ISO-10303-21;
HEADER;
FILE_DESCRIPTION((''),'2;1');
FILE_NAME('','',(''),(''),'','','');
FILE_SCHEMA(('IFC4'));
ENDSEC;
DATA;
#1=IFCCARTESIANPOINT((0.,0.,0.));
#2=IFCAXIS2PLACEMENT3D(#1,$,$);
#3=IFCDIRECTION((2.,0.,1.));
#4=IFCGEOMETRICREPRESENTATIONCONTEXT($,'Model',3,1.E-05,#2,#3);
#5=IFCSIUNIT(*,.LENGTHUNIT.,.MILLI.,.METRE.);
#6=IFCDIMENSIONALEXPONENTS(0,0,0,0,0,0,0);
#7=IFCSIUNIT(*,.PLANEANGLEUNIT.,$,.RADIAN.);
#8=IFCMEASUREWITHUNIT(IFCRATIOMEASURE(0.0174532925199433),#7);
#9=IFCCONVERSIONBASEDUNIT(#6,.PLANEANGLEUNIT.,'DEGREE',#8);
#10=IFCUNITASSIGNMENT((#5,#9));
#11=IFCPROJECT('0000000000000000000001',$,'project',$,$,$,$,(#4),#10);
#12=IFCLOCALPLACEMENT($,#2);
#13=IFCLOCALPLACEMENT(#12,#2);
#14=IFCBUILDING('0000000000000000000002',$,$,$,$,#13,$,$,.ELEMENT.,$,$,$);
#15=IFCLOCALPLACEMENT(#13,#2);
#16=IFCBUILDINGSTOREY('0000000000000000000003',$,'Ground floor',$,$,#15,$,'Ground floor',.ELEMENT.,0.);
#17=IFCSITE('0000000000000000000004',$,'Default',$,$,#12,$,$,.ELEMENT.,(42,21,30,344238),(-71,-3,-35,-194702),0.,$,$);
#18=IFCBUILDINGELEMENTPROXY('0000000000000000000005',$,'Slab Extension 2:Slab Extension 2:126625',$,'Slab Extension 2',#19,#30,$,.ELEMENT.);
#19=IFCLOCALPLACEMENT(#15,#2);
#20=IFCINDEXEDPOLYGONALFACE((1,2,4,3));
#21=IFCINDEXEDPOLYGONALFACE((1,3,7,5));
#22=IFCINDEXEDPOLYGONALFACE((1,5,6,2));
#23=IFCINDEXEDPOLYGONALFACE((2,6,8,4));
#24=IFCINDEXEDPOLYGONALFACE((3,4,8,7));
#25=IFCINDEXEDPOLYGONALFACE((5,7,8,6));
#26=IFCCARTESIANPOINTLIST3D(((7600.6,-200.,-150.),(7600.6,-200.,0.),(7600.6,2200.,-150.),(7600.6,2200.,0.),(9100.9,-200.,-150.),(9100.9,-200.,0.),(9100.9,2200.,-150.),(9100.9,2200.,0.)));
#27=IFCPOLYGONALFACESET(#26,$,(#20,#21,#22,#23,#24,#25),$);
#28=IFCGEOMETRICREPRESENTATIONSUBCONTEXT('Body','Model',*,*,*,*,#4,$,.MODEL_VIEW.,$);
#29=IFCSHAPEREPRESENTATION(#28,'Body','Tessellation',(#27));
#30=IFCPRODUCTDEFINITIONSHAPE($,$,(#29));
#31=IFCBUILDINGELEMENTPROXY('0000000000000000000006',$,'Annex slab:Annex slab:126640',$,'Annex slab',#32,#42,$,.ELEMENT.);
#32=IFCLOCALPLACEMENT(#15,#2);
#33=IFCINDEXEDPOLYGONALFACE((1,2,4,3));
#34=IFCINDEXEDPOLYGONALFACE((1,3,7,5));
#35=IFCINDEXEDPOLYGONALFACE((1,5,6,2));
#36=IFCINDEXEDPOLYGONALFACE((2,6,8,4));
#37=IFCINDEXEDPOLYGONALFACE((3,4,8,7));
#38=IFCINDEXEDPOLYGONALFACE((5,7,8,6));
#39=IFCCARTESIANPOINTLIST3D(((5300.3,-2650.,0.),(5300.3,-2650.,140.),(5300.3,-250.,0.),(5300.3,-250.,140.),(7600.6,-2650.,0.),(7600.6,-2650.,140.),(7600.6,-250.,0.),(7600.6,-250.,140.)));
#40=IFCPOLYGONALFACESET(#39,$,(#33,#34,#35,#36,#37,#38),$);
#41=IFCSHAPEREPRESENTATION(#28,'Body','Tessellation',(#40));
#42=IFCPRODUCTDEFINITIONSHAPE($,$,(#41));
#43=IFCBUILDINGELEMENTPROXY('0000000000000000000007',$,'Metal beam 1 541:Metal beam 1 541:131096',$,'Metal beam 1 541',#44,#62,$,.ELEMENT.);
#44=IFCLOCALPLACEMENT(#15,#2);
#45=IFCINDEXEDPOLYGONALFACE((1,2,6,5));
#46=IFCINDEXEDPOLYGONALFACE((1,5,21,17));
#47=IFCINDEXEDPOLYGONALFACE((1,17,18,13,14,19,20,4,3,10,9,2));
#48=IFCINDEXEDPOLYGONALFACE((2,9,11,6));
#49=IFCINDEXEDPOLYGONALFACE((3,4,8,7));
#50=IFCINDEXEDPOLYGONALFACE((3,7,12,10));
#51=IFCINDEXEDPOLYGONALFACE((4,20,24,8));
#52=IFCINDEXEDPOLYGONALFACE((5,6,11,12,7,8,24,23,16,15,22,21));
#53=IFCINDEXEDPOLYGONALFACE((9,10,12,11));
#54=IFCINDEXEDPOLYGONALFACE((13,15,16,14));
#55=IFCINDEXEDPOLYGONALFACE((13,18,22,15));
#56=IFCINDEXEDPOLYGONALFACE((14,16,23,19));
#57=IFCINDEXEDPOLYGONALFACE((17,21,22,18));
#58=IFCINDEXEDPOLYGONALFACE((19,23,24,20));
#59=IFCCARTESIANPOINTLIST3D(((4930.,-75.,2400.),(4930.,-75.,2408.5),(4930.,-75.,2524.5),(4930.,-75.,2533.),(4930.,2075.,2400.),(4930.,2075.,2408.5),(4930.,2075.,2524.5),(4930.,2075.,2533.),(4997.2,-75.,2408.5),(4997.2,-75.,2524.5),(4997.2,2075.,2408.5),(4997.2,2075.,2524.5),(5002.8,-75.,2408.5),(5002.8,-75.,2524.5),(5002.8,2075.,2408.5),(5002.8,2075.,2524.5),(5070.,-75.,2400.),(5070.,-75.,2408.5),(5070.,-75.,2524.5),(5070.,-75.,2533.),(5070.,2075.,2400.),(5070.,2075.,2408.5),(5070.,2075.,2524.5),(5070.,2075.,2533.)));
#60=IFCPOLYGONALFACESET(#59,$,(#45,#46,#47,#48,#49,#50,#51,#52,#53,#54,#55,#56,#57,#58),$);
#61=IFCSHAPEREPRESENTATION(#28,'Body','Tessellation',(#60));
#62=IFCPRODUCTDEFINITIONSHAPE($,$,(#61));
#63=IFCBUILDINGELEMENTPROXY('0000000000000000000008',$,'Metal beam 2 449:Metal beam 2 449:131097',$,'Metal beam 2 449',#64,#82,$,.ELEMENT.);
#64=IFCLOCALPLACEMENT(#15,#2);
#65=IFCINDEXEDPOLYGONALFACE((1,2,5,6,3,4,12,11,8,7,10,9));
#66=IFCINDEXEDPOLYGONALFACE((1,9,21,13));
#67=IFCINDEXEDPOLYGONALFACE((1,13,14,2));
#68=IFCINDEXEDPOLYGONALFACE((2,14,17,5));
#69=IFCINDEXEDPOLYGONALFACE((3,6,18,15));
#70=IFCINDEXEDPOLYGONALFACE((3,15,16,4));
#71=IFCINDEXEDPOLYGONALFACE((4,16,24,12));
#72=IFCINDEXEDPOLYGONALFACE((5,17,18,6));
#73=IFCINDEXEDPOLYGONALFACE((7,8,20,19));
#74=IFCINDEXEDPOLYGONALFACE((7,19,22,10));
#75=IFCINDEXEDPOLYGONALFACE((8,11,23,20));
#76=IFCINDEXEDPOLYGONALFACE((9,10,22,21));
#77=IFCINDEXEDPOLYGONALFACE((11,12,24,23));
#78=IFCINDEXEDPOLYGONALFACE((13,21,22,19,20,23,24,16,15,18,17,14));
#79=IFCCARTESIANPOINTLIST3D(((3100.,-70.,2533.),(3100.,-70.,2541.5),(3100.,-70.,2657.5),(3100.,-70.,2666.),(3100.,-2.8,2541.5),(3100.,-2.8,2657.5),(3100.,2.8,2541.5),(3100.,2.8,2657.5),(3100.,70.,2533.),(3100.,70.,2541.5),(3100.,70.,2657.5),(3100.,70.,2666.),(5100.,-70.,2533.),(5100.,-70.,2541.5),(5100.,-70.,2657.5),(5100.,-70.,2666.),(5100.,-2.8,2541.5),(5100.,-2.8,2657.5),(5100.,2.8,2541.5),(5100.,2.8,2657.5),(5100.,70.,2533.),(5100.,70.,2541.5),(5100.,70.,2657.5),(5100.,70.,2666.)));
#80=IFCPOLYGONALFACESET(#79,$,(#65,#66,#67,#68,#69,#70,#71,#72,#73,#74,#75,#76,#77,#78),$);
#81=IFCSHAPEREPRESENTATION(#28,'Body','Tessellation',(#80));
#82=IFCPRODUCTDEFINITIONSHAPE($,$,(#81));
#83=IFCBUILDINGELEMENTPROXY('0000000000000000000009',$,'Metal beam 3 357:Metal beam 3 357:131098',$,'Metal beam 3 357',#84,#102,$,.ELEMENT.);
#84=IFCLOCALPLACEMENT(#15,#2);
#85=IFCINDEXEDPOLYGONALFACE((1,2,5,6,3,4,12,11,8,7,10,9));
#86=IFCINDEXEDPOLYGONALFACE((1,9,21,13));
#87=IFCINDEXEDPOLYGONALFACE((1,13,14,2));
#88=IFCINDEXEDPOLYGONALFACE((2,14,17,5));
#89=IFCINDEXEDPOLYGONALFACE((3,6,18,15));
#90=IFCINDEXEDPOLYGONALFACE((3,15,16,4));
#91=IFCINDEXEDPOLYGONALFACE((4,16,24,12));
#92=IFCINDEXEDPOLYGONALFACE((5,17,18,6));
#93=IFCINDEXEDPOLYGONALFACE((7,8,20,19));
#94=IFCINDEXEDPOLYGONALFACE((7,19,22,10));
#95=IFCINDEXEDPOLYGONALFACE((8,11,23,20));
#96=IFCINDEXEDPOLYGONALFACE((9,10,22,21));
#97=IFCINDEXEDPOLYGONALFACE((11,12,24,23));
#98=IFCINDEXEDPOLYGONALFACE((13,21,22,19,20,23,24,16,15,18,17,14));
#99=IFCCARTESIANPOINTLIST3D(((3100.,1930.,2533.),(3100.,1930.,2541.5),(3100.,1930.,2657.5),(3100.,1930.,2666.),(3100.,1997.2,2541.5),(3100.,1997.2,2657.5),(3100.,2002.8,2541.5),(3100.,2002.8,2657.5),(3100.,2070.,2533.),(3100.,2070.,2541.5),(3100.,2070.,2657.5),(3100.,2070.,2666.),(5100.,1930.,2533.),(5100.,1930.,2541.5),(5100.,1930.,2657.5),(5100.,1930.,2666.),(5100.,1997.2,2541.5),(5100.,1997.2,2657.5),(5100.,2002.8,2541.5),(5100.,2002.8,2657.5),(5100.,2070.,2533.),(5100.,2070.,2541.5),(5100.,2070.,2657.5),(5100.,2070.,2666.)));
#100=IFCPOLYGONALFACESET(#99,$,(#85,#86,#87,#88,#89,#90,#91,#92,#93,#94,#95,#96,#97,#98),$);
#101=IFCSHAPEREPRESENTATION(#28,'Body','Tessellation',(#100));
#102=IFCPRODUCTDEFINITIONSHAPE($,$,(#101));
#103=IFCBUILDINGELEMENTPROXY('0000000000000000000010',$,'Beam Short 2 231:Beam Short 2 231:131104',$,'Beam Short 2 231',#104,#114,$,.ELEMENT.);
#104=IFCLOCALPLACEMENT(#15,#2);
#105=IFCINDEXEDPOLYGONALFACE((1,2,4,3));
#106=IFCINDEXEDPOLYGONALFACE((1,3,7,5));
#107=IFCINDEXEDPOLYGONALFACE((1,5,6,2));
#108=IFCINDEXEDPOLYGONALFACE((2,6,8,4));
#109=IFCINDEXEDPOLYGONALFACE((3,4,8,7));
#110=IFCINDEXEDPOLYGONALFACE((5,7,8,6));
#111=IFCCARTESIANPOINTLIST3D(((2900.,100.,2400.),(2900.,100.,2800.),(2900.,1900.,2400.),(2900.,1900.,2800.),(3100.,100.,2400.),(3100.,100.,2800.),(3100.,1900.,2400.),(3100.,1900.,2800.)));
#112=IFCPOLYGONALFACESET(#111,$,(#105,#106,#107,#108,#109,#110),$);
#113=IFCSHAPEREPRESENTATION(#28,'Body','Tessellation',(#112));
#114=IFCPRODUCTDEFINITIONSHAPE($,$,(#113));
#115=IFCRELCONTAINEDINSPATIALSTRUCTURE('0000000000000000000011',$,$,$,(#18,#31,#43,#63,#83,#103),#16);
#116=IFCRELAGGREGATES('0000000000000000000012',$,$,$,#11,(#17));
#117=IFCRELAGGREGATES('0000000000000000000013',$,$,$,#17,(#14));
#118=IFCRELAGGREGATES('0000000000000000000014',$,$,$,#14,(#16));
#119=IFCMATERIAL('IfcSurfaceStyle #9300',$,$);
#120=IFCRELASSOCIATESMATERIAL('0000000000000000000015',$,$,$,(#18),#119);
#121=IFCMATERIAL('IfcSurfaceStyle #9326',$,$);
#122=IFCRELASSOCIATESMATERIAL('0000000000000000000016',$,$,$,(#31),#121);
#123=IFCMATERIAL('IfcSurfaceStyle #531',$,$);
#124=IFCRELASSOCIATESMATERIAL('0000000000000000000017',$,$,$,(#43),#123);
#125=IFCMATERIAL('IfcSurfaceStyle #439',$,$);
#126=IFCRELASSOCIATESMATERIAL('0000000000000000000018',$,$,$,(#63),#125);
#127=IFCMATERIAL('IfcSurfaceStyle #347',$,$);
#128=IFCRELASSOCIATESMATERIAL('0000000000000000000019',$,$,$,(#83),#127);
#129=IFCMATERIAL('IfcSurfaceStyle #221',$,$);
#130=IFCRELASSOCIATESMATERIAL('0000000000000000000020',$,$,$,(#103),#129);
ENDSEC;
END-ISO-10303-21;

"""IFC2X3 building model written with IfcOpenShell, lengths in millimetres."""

from ifc_helpers import new_model, entity, si_unit, converted_unit, direction, frame, frame_2d, origin, origin_2d_with_axis, place, context, subcontext, project, spatial, rectangle, i_section, extrude, source, transform, mapped, material, element, save


model = new_model("IFC2X3")

# Units and contexts
model_context = context("Model", 3, precision=1e-05, world=origin(), true_north=direction((2.0, 0.0, 1.0)))
body_context = subcontext(model_context, "Body", "Model", "MODEL_VIEW")
ifc_project = project(units=[si_unit("LENGTHUNIT", "METRE", prefix="MILLI"), converted_unit("PLANEANGLEUNIT", "DEGREE", entity("IfcRatioMeasure", 0.0174532925199433), si_unit("PLANEANGLEUNIT", "RADIAN"), dimensions=[0, 0, 0, 0, 0, 0, 0])], contexts=[model_context])

# Site, building, storey
site_placement = place(None, origin())
site = spatial("IfcSite", under=ifc_project, at=site_placement, Name="Default", CompositionType="ELEMENT", RefLatitude=(42, 21, 30, 344238), RefLongitude=(-71, -3, -35, -194702), RefElevation=0.0)
building_placement = place(site_placement, origin())
building = spatial("IfcBuilding", under=site, at=building_placement, CompositionType="ELEMENT")
storey_placement = place(building_placement, origin())
storey = spatial("IfcBuildingStorey", under=building, at=storey_placement, Name="Ground floor", LongName="Ground floor", CompositionType="ELEMENT", Elevation=0.0)

# Building element proxies
ifc_material_1 = material(Name="IfcSurfaceStyle #9300")
shared_shape_1 = source(origin(), body_context, "Body", "SweptSolid", [
    extrude(rectangle(XDim=1500.3, YDim=2400.0, at=origin_2d_with_axis()), frame((750.1, 1200.0, 0.0)), (0.0, 0.0, 1.0), 150.0),
])
proxy_1_placement = place(building_placement, frame((7600.6, -200.0, -150.0)))
element("IfcBuildingElementProxy", 1, at=proxy_1_placement, inside=storey, material=ifc_material_1, Name="Slab Extension 2:Slab Extension 2:126625", ObjectType="Slab Extension 2", CompositionType="ELEMENT", context=body_context, shape_type="MappedRepresentation", body=[
    mapped(shared_shape_1, transform((0.0, 0.0, 0.0), scale=1.0)),
])
ifc_material_2 = material(Name="IfcSurfaceStyle #9326")
shared_shape_2 = source(origin(), body_context, "Body", "SweptSolid", [
    extrude(rectangle(XDim=2300.3, YDim=2400.0, at=frame_2d((0.0, 0.0), x_axis=(1.0, 0.0))), frame((1150.2, 1200.0, 0.0)), (0.0, 0.0, 1.0), 140.0),
])
proxy_2_placement = place(building_placement, frame((5300.3, -2650.0, 0.0)))
element("IfcBuildingElementProxy", 2, at=proxy_2_placement, inside=storey, material=ifc_material_2, Name="Annex slab:Annex slab:126640", ObjectType="Annex slab", CompositionType="ELEMENT", context=body_context, shape_type="MappedRepresentation", body=[
    mapped(shared_shape_2, transform((0.0, 0.0, 0.0), scale=1.0)),
])
ifc_material_3 = material(Name="IfcSurfaceStyle #531")
shared_shape_3 = source(origin(), body_context, "Body", "SweptSolid", [
    extrude(i_section(OverallWidth=140.0, OverallDepth=133.0, WebThickness=5.5, FlangeThickness=8.5, at=frame_2d((0.0, 0.0), x_axis=(1.0, 0.0))), frame((70.0, 0.0, 66.5), z_axis=(0.0, 1.0, 0.0), x_axis=(-1.0, 0.0, 0.0)), (0.0, 0.0, 1.0), 2150.0),
])
proxy_3_placement = place(building_placement, frame((4930.0, -75.0, 2400.0)))
element("IfcBuildingElementProxy", 3, at=proxy_3_placement, inside=storey, material=ifc_material_3, Name="Metal beam 1 541:Metal beam 1 541:131096", ObjectType="Metal beam 1 541", CompositionType="ELEMENT", context=body_context, shape_type="MappedRepresentation", body=[
    mapped(shared_shape_3, transform((0.0, 0.0, 0.0), scale=1.0)),
])
ifc_material_4 = material(Name="IfcSurfaceStyle #439")
shared_shape_4 = source(origin(), body_context, "Body", "SweptSolid", [
    extrude(i_section(OverallWidth=140.0, OverallDepth=133.0, WebThickness=5.5, FlangeThickness=8.5, at=frame_2d((0.0, 0.0), x_axis=(1.0, 0.0))), frame((0.0, 70.0, 66.5), z_axis=(1.0, 0.0, 0.0), x_axis=(0.0, 1.0, 0.0)), (0.0, 0.0, 1.0), 2000.0),
])
proxy_4_placement = place(building_placement, frame((3100.0, -70.0, 2533.0)))
element("IfcBuildingElementProxy", 4, at=proxy_4_placement, inside=storey, material=ifc_material_4, Name="Metal beam 2 449:Metal beam 2 449:131097", ObjectType="Metal beam 2 449", CompositionType="ELEMENT", context=body_context, shape_type="MappedRepresentation", body=[
    mapped(shared_shape_4, transform((0.0, 0.0, 0.0), scale=1.0)),
])
ifc_material_5 = material(Name="IfcSurfaceStyle #347")
shared_shape_5 = source(origin(), body_context, "Body", "SweptSolid", [
    extrude(i_section(OverallWidth=140.0, OverallDepth=133.0, WebThickness=5.5, FlangeThickness=8.5, at=frame_2d((0.0, 0.0), x_axis=(1.0, 0.0))), frame((0.0, 70.0, 66.5), z_axis=(1.0, 0.0, 0.0), x_axis=(0.0, 1.0, 0.0)), (0.0, 0.0, 1.0), 2000.0),
])
proxy_5_placement = place(building_placement, frame((3100.0, 1930.0, 2533.0)))
element("IfcBuildingElementProxy", 5, at=proxy_5_placement, inside=storey, material=ifc_material_5, Name="Metal beam 3 357:Metal beam 3 357:131098", ObjectType="Metal beam 3 357", CompositionType="ELEMENT", context=body_context, shape_type="MappedRepresentation", body=[
    mapped(shared_shape_5, transform((0.0, 0.0, 0.0), scale=1.0)),
])
ifc_material_6 = material(Name="IfcSurfaceStyle #221")
shared_shape_6 = source(origin(), body_context, "Body", "SweptSolid", [
    extrude(rectangle(XDim=1800.0, YDim=200.0, at=origin_2d_with_axis()), frame((100.0, 900.0, 0.0), z_axis=(0.0, 0.0, 1.0), x_axis=(0.0, -1.0, 0.0)), (0.0, 0.0, 1.0), 400.0),
])
proxy_6_placement = place(building_placement, frame((2900.0, 100.0, 2400.0)))
element("IfcBuildingElementProxy", 6, at=proxy_6_placement, inside=storey, material=ifc_material_6, Name="Beam Short 2 231:Beam Short 2 231:131104", ObjectType="Beam Short 2 231", CompositionType="ELEMENT", context=body_context, shape_type="MappedRepresentation", body=[
    mapped(shared_shape_6, transform((0.0, 0.0, 0.0), scale=1.0)),
])

save(model, "model.ifc")
